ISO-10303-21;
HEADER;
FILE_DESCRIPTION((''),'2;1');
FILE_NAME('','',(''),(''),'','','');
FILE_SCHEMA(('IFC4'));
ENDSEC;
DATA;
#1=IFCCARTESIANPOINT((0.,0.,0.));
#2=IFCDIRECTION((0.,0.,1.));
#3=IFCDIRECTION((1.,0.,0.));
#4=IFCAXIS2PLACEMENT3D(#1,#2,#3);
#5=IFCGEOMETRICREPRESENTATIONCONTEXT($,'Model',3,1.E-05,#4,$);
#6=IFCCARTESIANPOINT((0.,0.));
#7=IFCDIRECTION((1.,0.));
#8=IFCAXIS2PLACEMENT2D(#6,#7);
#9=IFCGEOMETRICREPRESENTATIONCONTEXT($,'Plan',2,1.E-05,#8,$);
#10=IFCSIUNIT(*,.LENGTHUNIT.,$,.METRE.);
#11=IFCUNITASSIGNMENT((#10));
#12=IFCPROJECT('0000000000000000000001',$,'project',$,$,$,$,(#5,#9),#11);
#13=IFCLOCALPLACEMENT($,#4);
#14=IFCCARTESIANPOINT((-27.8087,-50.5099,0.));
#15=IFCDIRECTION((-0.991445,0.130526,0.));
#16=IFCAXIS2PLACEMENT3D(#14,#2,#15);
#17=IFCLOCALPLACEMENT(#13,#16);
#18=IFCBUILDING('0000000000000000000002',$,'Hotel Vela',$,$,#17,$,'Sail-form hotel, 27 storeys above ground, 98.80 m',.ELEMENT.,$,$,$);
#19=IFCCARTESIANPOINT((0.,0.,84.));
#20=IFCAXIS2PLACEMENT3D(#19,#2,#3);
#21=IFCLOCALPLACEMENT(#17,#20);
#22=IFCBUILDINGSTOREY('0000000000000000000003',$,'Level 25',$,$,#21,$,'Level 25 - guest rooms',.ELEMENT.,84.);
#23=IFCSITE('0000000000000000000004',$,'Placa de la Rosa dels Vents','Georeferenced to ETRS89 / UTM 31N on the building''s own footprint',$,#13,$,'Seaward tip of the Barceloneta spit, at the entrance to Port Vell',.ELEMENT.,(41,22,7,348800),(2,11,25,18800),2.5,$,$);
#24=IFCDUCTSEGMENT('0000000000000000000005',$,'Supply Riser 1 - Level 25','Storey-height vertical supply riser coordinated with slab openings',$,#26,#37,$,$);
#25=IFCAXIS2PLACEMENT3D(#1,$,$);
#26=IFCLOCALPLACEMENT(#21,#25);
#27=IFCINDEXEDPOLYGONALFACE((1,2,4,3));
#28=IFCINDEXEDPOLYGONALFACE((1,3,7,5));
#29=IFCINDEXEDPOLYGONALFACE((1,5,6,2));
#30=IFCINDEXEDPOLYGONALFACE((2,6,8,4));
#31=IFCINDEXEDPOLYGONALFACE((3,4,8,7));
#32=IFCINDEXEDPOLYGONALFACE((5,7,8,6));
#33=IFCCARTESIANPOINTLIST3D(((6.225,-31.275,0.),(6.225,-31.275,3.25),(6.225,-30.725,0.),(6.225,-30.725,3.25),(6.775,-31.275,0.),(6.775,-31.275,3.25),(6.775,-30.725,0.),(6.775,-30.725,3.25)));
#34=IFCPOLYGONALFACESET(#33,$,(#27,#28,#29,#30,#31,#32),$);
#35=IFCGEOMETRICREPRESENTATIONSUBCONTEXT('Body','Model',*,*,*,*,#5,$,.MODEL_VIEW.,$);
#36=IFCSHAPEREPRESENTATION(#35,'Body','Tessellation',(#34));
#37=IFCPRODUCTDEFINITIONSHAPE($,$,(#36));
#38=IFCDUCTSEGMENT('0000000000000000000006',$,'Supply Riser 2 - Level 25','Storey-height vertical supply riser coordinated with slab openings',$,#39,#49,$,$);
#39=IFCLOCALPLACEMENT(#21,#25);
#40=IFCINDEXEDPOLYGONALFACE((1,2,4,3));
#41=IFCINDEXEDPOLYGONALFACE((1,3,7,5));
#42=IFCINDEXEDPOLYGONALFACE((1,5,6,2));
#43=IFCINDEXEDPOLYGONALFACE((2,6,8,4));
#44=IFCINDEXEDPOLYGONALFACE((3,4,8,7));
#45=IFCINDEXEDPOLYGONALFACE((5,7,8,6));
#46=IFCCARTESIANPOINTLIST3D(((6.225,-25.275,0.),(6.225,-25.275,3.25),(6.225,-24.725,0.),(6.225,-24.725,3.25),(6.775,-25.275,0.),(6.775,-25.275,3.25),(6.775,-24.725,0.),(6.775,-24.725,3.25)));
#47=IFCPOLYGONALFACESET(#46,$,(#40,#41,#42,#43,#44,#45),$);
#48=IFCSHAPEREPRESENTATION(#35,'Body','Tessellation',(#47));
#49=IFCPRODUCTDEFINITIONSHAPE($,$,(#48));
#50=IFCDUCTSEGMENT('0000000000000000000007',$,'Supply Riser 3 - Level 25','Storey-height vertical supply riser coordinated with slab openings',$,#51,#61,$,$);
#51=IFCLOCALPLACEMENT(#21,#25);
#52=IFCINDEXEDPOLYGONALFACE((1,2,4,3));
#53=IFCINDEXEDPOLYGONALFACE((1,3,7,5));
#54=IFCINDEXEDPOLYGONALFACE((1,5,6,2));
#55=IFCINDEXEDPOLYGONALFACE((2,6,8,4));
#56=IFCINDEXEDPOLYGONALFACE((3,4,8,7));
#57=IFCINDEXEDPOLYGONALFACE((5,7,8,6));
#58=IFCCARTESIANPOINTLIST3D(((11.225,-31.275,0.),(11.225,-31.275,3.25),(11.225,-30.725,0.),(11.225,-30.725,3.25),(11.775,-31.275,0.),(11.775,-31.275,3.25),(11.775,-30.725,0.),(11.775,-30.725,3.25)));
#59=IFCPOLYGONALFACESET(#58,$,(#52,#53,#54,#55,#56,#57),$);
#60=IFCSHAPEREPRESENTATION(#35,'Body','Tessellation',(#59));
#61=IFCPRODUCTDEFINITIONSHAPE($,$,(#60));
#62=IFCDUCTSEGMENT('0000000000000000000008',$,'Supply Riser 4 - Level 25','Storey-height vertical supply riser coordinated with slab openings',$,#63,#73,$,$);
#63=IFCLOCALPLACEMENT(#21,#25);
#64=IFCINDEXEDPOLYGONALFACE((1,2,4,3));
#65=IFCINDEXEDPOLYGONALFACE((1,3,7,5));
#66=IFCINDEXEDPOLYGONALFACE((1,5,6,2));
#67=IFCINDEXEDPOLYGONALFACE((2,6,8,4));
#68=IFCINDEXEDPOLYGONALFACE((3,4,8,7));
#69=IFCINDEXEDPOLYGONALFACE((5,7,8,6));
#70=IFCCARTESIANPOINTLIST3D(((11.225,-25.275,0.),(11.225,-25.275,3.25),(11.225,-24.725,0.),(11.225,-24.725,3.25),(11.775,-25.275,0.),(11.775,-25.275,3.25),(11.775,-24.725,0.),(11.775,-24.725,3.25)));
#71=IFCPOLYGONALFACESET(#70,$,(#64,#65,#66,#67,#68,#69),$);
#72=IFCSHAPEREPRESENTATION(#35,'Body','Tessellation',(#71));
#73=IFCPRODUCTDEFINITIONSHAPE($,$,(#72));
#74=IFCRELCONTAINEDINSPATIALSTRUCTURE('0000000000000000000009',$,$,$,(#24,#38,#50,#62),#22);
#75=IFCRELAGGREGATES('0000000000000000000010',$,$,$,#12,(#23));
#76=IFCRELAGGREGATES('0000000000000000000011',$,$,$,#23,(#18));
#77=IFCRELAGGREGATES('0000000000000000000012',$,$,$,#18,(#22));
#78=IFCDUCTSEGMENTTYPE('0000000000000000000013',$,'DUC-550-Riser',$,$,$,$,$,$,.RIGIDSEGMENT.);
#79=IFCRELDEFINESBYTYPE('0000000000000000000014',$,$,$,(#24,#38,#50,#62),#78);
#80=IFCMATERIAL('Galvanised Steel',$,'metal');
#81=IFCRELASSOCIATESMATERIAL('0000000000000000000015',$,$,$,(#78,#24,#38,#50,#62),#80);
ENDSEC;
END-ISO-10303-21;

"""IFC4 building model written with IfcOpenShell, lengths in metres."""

from ifc_helpers import new_model, si_unit, frame, origin_with_axes, origin_2d_with_axis, place, context, subcontext, project, spatial, line, indexed_curve, outline, extrude, material, type_object, element, save


model = new_model("IFC4")

# Units and contexts
model_context = context("Model", 3, precision=1e-05, world=origin_with_axes())
plan_context = context("Plan", 2, precision=1e-05, world=origin_2d_with_axis())
body_context = subcontext(model_context, "Body", "Model", "MODEL_VIEW")
ifc_project = project(units=[si_unit("LENGTHUNIT", "METRE")], contexts=[model_context, plan_context])

# Site, building, storey
site_placement = place(None, origin_with_axes())
site = spatial("IfcSite", under=ifc_project, at=site_placement, Name="Placa de la Rosa dels Vents", Description="Georeferenced to ETRS89 / UTM 31N on the building's own footprint", LongName="Seaward tip of the Barceloneta spit, at the entrance to Port Vell", CompositionType="ELEMENT", RefLatitude=(41, 22, 7, 348800), RefLongitude=(2, 11, 25, 18800), RefElevation=2.5)
building_placement = place(site_placement, frame((-27.8087, -50.5099, 0.0), z_axis=(0.0, 0.0, 1.0), x_axis=(-0.991445, 0.130526, 0.0)))
building = spatial("IfcBuilding", under=site, at=building_placement, Name="Hotel Vela", LongName="Sail-form hotel, 27 storeys above ground, 98.80 m", CompositionType="ELEMENT")
storey_placement = place(building_placement, frame((0.0, 0.0, 84.0), z_axis=(0.0, 0.0, 1.0), x_axis=(1.0, 0.0, 0.0)))
storey = spatial("IfcBuildingStorey", under=building, at=storey_placement, Name="Level 25", LongName="Level 25 - guest rooms", CompositionType="ELEMENT", Elevation=84.0)

# Duct segments
ifc_material = material(Name="Galvanised Steel", Category="metal")
duct_segment_type = type_object("IfcDuctSegmentType", Name="DUC-550-Riser", PredefinedType="RIGIDSEGMENT", material=ifc_material)
for number, where, z_axis, x_axis, name in (
    (1, (6.225, -31.275, 0.0), (0.0, 0.0, 1.0), (1.0, 0.0, 0.0), "Supply Riser 1 - Level 25"),
    (2, (6.225, -25.275, 0.0), (0.0, 0.0, 1.0), (1.0, 0.0, 0.0), "Supply Riser 2 - Level 25"),
    (3, (11.225, -31.275, 0.0), (0.0, 0.0, 1.0), (1.0, 0.0, 0.0), "Supply Riser 3 - Level 25"),
    (4, (11.225, -25.275, 0.0), (0.0, 0.0, 1.0), (1.0, 0.0, 0.0), "Supply Riser 4 - Level 25"),
):
    element("IfcDuctSegment", number, at=place(storey_placement, frame(where, z_axis=z_axis, x_axis=x_axis)), inside=storey, type_object=duct_segment_type, material=ifc_material, Name=name, Description="Storey-height vertical supply riser coordinated with slab openings", context=body_context, shape_type="SweptSolid", body=[
        extrude(outline(indexed_curve([(0.0, 0.0), (0.55, 0.0), (0.55, 0.55), (0.0, 0.55)], segments=[line(1, 2, 3, 4, 1)])), origin_with_axes(), (0.0, 0.0, 1.0), 3.25),
    ])

save(model, "model.ifc")
